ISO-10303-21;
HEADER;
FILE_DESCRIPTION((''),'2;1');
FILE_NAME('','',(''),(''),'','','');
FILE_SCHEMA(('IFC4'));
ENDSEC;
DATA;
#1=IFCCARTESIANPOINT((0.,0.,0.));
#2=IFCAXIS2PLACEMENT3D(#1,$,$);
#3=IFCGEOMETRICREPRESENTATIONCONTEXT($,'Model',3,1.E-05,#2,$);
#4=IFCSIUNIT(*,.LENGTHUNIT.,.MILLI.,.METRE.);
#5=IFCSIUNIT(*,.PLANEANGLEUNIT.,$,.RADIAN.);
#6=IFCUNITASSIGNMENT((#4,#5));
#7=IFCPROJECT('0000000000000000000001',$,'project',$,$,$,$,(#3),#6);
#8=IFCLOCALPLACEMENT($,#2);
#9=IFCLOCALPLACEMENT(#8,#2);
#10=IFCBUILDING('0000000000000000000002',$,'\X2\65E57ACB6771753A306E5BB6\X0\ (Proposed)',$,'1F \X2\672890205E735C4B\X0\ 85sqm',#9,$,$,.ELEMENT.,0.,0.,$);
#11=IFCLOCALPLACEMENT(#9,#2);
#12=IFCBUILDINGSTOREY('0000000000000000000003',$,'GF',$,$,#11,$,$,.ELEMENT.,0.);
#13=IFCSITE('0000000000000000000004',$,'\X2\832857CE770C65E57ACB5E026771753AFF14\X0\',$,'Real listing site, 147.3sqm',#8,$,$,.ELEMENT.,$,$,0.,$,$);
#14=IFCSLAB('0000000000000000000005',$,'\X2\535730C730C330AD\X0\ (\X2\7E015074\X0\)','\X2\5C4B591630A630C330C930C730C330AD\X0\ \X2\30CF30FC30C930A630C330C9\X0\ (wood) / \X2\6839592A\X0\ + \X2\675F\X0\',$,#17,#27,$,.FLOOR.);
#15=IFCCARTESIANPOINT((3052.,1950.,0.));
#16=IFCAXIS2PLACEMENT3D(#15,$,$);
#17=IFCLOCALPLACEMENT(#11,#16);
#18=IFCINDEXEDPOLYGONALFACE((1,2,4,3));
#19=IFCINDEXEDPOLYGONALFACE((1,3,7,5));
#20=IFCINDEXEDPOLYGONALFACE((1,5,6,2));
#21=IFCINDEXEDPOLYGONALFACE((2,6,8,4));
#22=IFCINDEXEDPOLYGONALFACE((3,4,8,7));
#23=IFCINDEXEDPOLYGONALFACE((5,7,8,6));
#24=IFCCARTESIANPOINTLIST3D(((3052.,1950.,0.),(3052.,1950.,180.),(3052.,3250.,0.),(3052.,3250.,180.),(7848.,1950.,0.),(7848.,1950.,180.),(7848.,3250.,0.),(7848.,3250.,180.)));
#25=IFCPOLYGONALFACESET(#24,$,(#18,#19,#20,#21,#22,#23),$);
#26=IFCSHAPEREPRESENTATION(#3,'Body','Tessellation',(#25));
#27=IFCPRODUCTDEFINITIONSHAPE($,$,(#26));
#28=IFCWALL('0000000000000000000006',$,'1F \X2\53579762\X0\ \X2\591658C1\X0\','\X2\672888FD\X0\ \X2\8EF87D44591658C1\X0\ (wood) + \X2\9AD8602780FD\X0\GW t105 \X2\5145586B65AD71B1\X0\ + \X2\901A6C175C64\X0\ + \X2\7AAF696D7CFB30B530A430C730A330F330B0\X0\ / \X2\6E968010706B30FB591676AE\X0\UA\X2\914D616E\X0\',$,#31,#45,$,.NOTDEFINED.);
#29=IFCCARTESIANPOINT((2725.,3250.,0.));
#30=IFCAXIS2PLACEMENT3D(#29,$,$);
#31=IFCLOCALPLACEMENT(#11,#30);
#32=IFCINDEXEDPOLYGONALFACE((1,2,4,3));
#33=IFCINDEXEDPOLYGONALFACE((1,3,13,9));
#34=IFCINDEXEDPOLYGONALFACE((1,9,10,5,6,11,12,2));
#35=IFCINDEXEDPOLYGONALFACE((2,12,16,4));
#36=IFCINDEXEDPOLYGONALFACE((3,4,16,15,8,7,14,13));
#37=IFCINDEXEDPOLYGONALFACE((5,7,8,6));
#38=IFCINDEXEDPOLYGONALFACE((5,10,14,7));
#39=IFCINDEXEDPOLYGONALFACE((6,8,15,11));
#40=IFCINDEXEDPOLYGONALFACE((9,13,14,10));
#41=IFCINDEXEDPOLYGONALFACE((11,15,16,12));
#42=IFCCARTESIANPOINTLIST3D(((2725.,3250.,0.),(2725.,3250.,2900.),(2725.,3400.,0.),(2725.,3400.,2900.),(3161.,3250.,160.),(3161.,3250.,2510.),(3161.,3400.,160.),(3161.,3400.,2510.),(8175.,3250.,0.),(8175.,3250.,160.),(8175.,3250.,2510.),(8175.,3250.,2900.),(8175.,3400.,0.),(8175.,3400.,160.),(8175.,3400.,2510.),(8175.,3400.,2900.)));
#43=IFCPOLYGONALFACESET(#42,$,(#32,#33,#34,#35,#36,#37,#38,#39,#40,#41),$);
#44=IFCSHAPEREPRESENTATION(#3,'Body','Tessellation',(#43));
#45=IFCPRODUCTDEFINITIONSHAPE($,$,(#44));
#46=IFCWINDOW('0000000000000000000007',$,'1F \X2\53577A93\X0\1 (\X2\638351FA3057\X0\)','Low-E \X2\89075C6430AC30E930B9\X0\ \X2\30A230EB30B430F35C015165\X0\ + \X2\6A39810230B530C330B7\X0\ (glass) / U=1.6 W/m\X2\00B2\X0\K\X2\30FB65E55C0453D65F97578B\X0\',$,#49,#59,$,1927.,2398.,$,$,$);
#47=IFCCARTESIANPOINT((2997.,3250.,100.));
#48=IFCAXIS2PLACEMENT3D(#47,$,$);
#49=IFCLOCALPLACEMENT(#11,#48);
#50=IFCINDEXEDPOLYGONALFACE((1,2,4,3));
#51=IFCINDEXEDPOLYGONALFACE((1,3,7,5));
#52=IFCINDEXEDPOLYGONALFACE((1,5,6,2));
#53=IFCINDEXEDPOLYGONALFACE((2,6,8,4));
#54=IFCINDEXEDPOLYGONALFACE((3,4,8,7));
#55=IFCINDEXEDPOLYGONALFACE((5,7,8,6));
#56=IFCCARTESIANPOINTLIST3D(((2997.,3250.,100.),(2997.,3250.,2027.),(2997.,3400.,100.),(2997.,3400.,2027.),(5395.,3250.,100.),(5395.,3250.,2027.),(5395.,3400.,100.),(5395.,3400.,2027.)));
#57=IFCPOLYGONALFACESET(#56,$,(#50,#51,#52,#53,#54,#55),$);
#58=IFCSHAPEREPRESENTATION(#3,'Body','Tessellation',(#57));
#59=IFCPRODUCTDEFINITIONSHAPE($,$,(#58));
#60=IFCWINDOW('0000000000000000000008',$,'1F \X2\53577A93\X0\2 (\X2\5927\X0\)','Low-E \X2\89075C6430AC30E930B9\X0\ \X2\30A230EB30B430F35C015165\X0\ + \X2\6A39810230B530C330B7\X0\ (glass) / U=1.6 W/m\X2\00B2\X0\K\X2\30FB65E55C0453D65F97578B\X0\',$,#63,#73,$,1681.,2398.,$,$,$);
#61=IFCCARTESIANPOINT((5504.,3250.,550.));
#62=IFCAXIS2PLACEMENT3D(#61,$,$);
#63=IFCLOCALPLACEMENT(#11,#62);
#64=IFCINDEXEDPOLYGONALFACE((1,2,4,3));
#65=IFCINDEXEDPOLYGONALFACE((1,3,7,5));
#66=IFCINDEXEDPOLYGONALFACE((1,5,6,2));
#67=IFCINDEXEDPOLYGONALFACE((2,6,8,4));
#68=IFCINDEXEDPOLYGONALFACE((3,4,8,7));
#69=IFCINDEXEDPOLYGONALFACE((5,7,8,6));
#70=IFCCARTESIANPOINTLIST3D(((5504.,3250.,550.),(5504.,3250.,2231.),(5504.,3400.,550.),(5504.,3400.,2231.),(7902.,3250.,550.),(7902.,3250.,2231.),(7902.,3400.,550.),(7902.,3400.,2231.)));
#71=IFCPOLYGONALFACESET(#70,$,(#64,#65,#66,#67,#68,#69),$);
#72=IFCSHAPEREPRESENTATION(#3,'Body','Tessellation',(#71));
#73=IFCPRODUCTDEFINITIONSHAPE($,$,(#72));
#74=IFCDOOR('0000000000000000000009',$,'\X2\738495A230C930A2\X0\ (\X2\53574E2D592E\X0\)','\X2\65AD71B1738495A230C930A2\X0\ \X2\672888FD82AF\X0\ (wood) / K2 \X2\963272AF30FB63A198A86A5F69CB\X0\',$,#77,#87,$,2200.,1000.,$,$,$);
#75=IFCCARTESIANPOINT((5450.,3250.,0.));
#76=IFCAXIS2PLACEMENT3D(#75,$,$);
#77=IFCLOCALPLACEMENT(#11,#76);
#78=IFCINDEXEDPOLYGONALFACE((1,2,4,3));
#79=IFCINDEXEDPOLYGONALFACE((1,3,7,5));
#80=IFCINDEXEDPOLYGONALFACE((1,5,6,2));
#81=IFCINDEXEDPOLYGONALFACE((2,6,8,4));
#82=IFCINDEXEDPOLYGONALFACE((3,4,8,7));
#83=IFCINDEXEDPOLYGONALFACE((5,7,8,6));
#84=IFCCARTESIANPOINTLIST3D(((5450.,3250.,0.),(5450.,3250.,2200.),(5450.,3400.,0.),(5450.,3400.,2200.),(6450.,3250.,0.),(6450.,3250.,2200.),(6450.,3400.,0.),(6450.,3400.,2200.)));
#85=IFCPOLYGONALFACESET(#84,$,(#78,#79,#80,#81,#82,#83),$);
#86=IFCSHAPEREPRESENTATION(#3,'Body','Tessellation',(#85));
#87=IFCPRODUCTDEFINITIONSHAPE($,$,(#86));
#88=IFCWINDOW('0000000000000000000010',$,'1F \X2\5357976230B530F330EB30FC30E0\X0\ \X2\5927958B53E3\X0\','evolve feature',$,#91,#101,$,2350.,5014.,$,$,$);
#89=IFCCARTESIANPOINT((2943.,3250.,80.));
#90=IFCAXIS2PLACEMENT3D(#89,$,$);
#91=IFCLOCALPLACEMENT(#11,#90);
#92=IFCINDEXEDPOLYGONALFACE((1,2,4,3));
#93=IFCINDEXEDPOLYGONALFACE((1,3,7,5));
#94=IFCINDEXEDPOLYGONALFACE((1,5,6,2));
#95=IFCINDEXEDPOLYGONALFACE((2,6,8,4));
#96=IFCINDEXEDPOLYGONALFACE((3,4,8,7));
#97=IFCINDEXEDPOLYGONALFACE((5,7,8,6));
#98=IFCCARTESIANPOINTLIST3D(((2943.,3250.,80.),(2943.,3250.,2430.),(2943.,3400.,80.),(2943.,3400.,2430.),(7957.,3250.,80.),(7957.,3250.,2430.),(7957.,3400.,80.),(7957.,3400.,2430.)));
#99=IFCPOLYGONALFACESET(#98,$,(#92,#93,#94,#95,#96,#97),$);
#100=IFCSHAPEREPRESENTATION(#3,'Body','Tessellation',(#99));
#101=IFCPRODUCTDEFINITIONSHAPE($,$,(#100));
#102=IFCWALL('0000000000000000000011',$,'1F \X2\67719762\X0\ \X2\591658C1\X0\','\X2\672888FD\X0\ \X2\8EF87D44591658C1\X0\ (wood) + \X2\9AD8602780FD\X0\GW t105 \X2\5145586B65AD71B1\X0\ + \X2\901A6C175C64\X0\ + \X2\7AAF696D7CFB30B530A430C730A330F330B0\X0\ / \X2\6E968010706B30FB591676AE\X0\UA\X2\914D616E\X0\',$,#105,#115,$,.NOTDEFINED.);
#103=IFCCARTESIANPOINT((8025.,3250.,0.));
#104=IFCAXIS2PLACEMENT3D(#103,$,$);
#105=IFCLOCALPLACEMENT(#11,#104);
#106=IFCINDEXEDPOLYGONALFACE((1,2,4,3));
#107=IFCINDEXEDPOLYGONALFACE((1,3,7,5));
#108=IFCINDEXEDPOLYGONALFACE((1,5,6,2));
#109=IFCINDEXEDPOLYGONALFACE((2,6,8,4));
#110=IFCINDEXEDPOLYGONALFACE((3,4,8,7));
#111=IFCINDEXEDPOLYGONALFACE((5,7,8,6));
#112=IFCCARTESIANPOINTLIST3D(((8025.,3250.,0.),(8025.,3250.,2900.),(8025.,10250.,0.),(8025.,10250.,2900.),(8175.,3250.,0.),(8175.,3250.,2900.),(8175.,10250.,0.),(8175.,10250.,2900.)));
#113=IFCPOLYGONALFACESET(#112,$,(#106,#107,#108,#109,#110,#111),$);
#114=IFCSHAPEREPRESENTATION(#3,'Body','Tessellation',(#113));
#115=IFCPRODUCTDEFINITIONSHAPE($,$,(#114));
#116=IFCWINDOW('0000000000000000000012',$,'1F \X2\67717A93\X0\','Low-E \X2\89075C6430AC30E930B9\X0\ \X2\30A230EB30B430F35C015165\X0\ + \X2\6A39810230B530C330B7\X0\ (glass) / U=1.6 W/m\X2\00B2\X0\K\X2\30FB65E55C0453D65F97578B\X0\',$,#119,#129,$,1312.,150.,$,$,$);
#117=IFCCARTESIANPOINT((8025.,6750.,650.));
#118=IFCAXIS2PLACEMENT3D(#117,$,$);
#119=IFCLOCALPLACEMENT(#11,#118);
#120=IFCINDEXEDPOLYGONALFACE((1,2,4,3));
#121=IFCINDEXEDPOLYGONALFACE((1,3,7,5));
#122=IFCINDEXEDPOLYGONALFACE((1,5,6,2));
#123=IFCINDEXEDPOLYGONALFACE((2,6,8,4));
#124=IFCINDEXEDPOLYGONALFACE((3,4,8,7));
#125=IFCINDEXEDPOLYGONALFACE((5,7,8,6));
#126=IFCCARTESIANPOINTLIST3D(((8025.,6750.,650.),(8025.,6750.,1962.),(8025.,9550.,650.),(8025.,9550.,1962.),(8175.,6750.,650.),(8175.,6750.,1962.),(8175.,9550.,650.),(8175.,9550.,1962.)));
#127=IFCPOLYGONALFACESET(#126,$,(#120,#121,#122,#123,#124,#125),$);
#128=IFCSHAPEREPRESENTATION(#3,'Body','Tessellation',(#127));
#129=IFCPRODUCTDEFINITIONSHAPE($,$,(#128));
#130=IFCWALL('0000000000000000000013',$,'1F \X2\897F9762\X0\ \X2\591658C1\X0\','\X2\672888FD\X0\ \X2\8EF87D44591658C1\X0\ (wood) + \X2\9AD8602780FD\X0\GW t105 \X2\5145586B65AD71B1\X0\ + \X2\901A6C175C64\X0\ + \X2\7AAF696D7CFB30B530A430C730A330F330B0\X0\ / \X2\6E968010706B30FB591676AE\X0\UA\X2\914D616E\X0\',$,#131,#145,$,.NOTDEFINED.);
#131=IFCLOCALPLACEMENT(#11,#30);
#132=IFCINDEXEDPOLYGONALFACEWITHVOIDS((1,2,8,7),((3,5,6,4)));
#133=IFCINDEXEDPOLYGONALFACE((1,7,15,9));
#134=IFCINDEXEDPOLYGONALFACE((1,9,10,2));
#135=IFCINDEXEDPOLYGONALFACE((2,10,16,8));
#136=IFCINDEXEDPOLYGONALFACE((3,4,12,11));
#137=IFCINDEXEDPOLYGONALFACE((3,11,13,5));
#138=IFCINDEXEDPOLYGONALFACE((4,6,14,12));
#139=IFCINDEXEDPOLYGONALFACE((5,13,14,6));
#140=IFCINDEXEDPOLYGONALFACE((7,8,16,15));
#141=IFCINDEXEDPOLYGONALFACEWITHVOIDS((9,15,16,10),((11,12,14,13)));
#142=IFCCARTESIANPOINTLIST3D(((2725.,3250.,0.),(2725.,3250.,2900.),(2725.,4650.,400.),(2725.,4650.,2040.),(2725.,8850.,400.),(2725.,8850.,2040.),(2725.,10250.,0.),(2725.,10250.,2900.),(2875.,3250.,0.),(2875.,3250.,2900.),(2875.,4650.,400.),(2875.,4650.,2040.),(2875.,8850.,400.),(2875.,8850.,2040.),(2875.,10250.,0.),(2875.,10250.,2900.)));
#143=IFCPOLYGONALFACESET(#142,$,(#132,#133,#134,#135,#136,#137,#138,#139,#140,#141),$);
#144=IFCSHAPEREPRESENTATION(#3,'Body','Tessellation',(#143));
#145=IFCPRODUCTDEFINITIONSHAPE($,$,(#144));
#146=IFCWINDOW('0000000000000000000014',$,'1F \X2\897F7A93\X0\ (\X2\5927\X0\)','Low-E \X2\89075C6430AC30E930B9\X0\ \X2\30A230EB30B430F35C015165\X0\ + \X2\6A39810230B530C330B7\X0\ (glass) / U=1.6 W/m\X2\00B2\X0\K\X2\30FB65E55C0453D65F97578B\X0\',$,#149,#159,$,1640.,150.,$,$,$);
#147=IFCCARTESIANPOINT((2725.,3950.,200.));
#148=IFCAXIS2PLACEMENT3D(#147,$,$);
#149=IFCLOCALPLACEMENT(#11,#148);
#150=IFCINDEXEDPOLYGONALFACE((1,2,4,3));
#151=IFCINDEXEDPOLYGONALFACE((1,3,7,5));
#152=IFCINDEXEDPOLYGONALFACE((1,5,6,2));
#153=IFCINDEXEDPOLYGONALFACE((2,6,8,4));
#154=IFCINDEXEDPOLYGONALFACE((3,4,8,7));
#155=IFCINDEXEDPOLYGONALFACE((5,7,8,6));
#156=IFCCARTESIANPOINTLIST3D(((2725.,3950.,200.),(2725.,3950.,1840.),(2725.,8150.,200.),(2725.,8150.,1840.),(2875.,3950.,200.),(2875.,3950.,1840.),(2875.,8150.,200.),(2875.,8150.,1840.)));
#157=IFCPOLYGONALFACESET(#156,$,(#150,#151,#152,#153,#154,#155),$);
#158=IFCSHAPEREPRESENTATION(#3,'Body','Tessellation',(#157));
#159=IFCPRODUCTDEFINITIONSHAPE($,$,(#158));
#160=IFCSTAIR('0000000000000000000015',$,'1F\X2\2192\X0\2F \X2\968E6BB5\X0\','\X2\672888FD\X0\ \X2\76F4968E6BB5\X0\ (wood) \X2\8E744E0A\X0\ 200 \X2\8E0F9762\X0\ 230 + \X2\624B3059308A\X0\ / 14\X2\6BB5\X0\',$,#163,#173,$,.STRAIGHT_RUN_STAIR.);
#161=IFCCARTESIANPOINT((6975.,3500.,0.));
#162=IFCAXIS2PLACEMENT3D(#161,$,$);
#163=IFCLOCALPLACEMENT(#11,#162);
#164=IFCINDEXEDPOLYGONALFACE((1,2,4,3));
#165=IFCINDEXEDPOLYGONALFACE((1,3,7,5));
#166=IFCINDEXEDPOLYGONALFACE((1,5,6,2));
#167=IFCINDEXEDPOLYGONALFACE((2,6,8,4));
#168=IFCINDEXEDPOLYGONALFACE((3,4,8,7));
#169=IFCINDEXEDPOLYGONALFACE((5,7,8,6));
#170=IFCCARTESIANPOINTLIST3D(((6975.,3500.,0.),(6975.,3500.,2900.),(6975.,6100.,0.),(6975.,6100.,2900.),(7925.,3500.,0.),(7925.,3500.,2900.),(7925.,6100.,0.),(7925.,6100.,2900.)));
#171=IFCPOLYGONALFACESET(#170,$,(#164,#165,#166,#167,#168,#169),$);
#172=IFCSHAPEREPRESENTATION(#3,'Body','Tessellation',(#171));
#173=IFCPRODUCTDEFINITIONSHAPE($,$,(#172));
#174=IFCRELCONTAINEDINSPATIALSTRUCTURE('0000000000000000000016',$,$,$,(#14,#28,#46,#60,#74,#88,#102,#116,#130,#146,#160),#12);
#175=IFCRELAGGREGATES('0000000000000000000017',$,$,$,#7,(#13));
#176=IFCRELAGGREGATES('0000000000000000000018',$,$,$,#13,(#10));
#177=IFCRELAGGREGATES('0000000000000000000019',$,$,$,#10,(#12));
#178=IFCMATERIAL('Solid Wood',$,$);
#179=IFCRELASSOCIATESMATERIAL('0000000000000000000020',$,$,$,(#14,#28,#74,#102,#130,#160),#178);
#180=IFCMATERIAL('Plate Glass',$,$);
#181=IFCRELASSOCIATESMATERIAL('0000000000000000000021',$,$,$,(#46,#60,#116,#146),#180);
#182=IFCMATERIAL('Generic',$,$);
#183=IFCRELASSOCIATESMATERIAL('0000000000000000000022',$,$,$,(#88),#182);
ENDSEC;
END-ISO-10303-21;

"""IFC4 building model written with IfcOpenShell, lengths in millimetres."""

from ifc_helpers import new_model, si_unit, frame, frame_2d, origin, place, context, project, spatial, rectangle, extrude, material, element, fill, save


model = new_model("IFC4")

# Units and contexts
model_context = context("Model", 3, precision=1e-05, world=origin())
ifc_project = project(units=[si_unit("LENGTHUNIT", "METRE", prefix="MILLI"), si_unit("PLANEANGLEUNIT", "RADIAN")], contexts=[model_context])

# Site, building, storey
site_placement = place(None, origin())
site = spatial("IfcSite", under=ifc_project, at=site_placement, Name="茨城県日立市東町４", ObjectType="Real listing site, 147.3sqm", CompositionType="ELEMENT", RefElevation=0.0)
building_placement = place(site_placement, origin())
building = spatial("IfcBuilding", under=site, at=building_placement, Name="日立東町の家 (Proposed)", ObjectType="1F 木造平屋 85sqm", CompositionType="ELEMENT", ElevationOfRefHeight=0.0, ElevationOfTerrain=0.0)
storey_placement = place(building_placement, origin())
storey = spatial("IfcBuildingStorey", under=building, at=storey_placement, Name="GF", CompositionType="ELEMENT", Elevation=0.0)

# Slab
ifc_material_1 = material(Name="Solid Wood")
slab_1_placement = place(storey_placement, frame((3052.0, 1950.0, 0.0)))
element("IfcSlab", 1, at=slab_1_placement, inside=storey, material=ifc_material_1, Name="南デッキ (縁側)", Description="屋外ウッドデッキ ハードウッド (wood) / 根太 + 束", PredefinedType="FLOOR", context=model_context, shape_type="SweptSolid", body=[
    extrude(rectangle(XDim=4796.0, YDim=1300.0, at=frame_2d((2398.0, 650.0))), frame((3052.0, 1950.0, 0.0)), (0.0, 0.0, 1.0), 180.0),
])
ifc_material_2 = material(Name="Generic")

# Wall, openings, windows, door
wall_1_placement = place(storey_placement, frame((2725.0, 3250.0, 0.0)))
wall_1 = element("IfcWall", 2, at=wall_1_placement, inside=storey, material=ifc_material_1, Name="1F 南面 外壁", Description="木製 軸組外壁 (wood) + 高性能GW t105 充填断熱 + 通気層 + 窯業系サイディング / 準耐火・外皮UA配慮", PredefinedType="NOTDEFINED", context=model_context, shape_type="SweptSolid", body=[
    extrude(rectangle(XDim=5450.0, YDim=150.0, at=frame_2d((2725.0, 75.0))), frame((2725.0, 3250.0, 0.0)), (0.0, 0.0, 1.0), 2900.0),
])
opening_1_placement = place(storey_placement, frame((2997.0, 3250.0, 100.0)))
opening_1 = element("IfcOpeningElement", 3, at=opening_1_placement, cuts=wall_1, PredefinedType="NOTDEFINED", context=model_context, shape_type="SweptSolid", body=[
    extrude(rectangle(XDim=2398.0, YDim=150.0, at=frame_2d((1199.0, 75.0))), frame((2997.0, 3250.0, 100.0)), (0.0, 0.0, 1.0), 1927.0),
])
opening_2_placement = place(storey_placement, frame((5504.0, 3250.0, 550.0)))
opening_2 = element("IfcOpeningElement", 4, at=opening_2_placement, cuts=wall_1, PredefinedType="NOTDEFINED", context=model_context, shape_type="SweptSolid", body=[
    extrude(rectangle(XDim=2398.0, YDim=150.0, at=frame_2d((1199.0, 75.0))), frame((5504.0, 3250.0, 550.0)), (0.0, 0.0, 1.0), 1681.0),
])
opening_3_placement = place(storey_placement, frame((5450.0, 3250.0, 0.0)))
opening_3 = element("IfcOpeningElement", 5, at=opening_3_placement, cuts=wall_1, PredefinedType="NOTDEFINED", context=model_context, shape_type="SweptSolid", body=[
    extrude(rectangle(XDim=1000.0, YDim=150.0, at=frame_2d((500.0, 75.0))), frame((5450.0, 3250.0, 0.0)), (0.0, 0.0, 1.0), 2200.0),
])
opening_4_placement = place(storey_placement, frame((2943.0, 3250.0, 80.0)))
opening_4 = element("IfcOpeningElement", 6, at=opening_4_placement, cuts=wall_1, PredefinedType="NOTDEFINED", context=model_context, shape_type="SweptSolid", body=[
    extrude(rectangle(XDim=5014.0, YDim=150.0, at=frame_2d((2507.0, 75.0))), frame((2943.0, 3250.0, 80.0)), (0.0, 0.0, 1.0), 2350.0),
])
ifc_material_3 = material(Name="Plate Glass")
window_1_placement = place(storey_placement, frame((2997.0, 3250.0, 100.0)))
window_1 = element("IfcWindow", 7, at=window_1_placement, inside=storey, material=ifc_material_3, Name="1F 南窓1 (掃出し)", Description="Low-E 複層ガラス アルゴン封入 + 樹脂サッシ (glass) / U=1.6 W/m²K・日射取得型", OverallHeight=1927.0, OverallWidth=2398.0, context=model_context, shape_type="SweptSolid", body=[
    extrude(rectangle(XDim=2398.0, YDim=150.0, at=frame_2d((1199.0, 75.0))), frame((2997.0, 3250.0, 100.0)), (0.0, 0.0, 1.0), 1927.0),
])
fill(opening_1, window_1)
window_2_placement = place(storey_placement, frame((5504.0, 3250.0, 550.0)))
window_2 = element("IfcWindow", 8, at=window_2_placement, inside=storey, material=ifc_material_3, Name="1F 南窓2 (大)", Description="Low-E 複層ガラス アルゴン封入 + 樹脂サッシ (glass) / U=1.6 W/m²K・日射取得型", OverallHeight=1681.0, OverallWidth=2398.0, context=model_context, shape_type="SweptSolid", body=[
    extrude(rectangle(XDim=2398.0, YDim=150.0, at=frame_2d((1199.0, 75.0))), frame((5504.0, 3250.0, 550.0)), (0.0, 0.0, 1.0), 1681.0),
])
fill(opening_2, window_2)
door_placement = place(storey_placement, frame((5450.0, 3250.0, 0.0)))
door = element("IfcDoor", 9, at=door_placement, inside=storey, material=ifc_material_1, Name="玄関ドア (南中央)", Description="断熱玄関ドア 木製芯 (wood) / K2 防犯・採風機構", OverallHeight=2200.0, OverallWidth=1000.0, context=model_context, shape_type="SweptSolid", body=[
    extrude(rectangle(XDim=1000.0, YDim=150.0, at=frame_2d((500.0, 75.0))), frame((5450.0, 3250.0, 0.0)), (0.0, 0.0, 1.0), 2200.0),
])
fill(opening_3, door)
window_3_placement = place(storey_placement, frame((2943.0, 3250.0, 80.0)))
window_3 = element("IfcWindow", 10, at=window_3_placement, inside=storey, material=ifc_material_2, Name="1F 南面サンルーム 大開口", Description="evolve feature", OverallHeight=2350.0, OverallWidth=5014.0, context=model_context, shape_type="SweptSolid", body=[
    extrude(rectangle(XDim=5014.0, YDim=150.0, at=frame_2d((2507.0, 75.0))), frame((2943.0, 3250.0, 80.0)), (0.0, 0.0, 1.0), 2350.0),
])
fill(opening_4, window_3)

# Walls, openings, windows
wall_2_placement = place(storey_placement, frame((8025.0, 3250.0, 0.0)))
wall_2 = element("IfcWall", 11, at=wall_2_placement, inside=storey, material=ifc_material_1, Name="1F 東面 外壁", Description="木製 軸組外壁 (wood) + 高性能GW t105 充填断熱 + 通気層 + 窯業系サイディング / 準耐火・外皮UA配慮", PredefinedType="NOTDEFINED", context=model_context, shape_type="SweptSolid", body=[
    extrude(rectangle(XDim=150.0, YDim=7000.0, at=frame_2d((75.0, 3500.0))), frame((8025.0, 3250.0, 0.0)), (0.0, 0.0, 1.0), 2900.0),
])
opening_5_placement = place(storey_placement, frame((8025.0, 6750.0, 650.0)))
opening_5 = element("IfcOpeningElement", 12, at=opening_5_placement, cuts=wall_2, PredefinedType="NOTDEFINED", context=model_context, shape_type="SweptSolid", body=[
    extrude(rectangle(XDim=150.0, YDim=2800.0, at=frame_2d((75.0, 1400.0))), frame((8025.0, 6750.0, 650.0)), (0.0, 0.0, 1.0), 1312.0),
])
window_4_placement = place(storey_placement, frame((8025.0, 6750.0, 650.0)))
window_4 = element("IfcWindow", 13, at=window_4_placement, inside=storey, material=ifc_material_3, Name="1F 東窓", Description="Low-E 複層ガラス アルゴン封入 + 樹脂サッシ (glass) / U=1.6 W/m²K・日射取得型", OverallHeight=1312.0, OverallWidth=150.0, context=model_context, shape_type="SweptSolid", body=[
    extrude(rectangle(XDim=150.0, YDim=2800.0, at=frame_2d((75.0, 1400.0))), frame((8025.0, 6750.0, 650.0)), (0.0, 0.0, 1.0), 1312.0),
])
fill(opening_5, window_4)
wall_3_placement = place(storey_placement, frame((2725.0, 3250.0, 0.0)))
wall_3 = element("IfcWall", 14, at=wall_3_placement, inside=storey, material=ifc_material_1, Name="1F 西面 外壁", Description="木製 軸組外壁 (wood) + 高性能GW t105 充填断熱 + 通気層 + 窯業系サイディング / 準耐火・外皮UA配慮", PredefinedType="NOTDEFINED", context=model_context, shape_type="SweptSolid", body=[
    extrude(rectangle(XDim=150.0, YDim=7000.0, at=frame_2d((75.0, 3500.0))), frame((2725.0, 3250.0, 0.0)), (0.0, 0.0, 1.0), 2900.0),
])
opening_6_placement = place(storey_placement, frame((2725.0, 3950.0, 200.0)))
opening_6 = element("IfcOpeningElement", 15, at=opening_6_placement, cuts=wall_3, PredefinedType="NOTDEFINED", context=model_context, shape_type="SweptSolid", body=[
    extrude(rectangle(XDim=150.0, YDim=4200.0, at=frame_2d((75.0, 2100.0))), frame((2725.0, 3950.0, 200.0)), (0.0, 0.0, 1.0), 1640.0),
])
window_5_placement = place(storey_placement, frame((2725.0, 3950.0, 200.0)))
window_5 = element("IfcWindow", 16, at=window_5_placement, inside=storey, material=ifc_material_3, Name="1F 西窓 (大)", Description="Low-E 複層ガラス アルゴン封入 + 樹脂サッシ (glass) / U=1.6 W/m²K・日射取得型", OverallHeight=1640.0, OverallWidth=150.0, context=model_context, shape_type="SweptSolid", body=[
    extrude(rectangle(XDim=150.0, YDim=4200.0, at=frame_2d((75.0, 2100.0))), frame((2725.0, 3950.0, 200.0)), (0.0, 0.0, 1.0), 1640.0),
])
fill(opening_6, window_5)

# Stair
stair_placement = place(storey_placement, frame((6975.0, 3500.0, 0.0)))
element("IfcStair", 17, at=stair_placement, inside=storey, material=ifc_material_1, Name="1F→2F 階段", Description="木製 直階段 (wood) 蹴上 200 踏面 230 + 手すり / 14段", PredefinedType="STRAIGHT_RUN_STAIR", context=model_context, shape_type="SweptSolid", body=[
    extrude(rectangle(XDim=950.0, YDim=2600.0, at=frame_2d((475.0, 1300.0))), frame((6975.0, 3500.0, 0.0)), (0.0, 0.0, 1.0), 2900.0),
])

save(model, "model.ifc")
